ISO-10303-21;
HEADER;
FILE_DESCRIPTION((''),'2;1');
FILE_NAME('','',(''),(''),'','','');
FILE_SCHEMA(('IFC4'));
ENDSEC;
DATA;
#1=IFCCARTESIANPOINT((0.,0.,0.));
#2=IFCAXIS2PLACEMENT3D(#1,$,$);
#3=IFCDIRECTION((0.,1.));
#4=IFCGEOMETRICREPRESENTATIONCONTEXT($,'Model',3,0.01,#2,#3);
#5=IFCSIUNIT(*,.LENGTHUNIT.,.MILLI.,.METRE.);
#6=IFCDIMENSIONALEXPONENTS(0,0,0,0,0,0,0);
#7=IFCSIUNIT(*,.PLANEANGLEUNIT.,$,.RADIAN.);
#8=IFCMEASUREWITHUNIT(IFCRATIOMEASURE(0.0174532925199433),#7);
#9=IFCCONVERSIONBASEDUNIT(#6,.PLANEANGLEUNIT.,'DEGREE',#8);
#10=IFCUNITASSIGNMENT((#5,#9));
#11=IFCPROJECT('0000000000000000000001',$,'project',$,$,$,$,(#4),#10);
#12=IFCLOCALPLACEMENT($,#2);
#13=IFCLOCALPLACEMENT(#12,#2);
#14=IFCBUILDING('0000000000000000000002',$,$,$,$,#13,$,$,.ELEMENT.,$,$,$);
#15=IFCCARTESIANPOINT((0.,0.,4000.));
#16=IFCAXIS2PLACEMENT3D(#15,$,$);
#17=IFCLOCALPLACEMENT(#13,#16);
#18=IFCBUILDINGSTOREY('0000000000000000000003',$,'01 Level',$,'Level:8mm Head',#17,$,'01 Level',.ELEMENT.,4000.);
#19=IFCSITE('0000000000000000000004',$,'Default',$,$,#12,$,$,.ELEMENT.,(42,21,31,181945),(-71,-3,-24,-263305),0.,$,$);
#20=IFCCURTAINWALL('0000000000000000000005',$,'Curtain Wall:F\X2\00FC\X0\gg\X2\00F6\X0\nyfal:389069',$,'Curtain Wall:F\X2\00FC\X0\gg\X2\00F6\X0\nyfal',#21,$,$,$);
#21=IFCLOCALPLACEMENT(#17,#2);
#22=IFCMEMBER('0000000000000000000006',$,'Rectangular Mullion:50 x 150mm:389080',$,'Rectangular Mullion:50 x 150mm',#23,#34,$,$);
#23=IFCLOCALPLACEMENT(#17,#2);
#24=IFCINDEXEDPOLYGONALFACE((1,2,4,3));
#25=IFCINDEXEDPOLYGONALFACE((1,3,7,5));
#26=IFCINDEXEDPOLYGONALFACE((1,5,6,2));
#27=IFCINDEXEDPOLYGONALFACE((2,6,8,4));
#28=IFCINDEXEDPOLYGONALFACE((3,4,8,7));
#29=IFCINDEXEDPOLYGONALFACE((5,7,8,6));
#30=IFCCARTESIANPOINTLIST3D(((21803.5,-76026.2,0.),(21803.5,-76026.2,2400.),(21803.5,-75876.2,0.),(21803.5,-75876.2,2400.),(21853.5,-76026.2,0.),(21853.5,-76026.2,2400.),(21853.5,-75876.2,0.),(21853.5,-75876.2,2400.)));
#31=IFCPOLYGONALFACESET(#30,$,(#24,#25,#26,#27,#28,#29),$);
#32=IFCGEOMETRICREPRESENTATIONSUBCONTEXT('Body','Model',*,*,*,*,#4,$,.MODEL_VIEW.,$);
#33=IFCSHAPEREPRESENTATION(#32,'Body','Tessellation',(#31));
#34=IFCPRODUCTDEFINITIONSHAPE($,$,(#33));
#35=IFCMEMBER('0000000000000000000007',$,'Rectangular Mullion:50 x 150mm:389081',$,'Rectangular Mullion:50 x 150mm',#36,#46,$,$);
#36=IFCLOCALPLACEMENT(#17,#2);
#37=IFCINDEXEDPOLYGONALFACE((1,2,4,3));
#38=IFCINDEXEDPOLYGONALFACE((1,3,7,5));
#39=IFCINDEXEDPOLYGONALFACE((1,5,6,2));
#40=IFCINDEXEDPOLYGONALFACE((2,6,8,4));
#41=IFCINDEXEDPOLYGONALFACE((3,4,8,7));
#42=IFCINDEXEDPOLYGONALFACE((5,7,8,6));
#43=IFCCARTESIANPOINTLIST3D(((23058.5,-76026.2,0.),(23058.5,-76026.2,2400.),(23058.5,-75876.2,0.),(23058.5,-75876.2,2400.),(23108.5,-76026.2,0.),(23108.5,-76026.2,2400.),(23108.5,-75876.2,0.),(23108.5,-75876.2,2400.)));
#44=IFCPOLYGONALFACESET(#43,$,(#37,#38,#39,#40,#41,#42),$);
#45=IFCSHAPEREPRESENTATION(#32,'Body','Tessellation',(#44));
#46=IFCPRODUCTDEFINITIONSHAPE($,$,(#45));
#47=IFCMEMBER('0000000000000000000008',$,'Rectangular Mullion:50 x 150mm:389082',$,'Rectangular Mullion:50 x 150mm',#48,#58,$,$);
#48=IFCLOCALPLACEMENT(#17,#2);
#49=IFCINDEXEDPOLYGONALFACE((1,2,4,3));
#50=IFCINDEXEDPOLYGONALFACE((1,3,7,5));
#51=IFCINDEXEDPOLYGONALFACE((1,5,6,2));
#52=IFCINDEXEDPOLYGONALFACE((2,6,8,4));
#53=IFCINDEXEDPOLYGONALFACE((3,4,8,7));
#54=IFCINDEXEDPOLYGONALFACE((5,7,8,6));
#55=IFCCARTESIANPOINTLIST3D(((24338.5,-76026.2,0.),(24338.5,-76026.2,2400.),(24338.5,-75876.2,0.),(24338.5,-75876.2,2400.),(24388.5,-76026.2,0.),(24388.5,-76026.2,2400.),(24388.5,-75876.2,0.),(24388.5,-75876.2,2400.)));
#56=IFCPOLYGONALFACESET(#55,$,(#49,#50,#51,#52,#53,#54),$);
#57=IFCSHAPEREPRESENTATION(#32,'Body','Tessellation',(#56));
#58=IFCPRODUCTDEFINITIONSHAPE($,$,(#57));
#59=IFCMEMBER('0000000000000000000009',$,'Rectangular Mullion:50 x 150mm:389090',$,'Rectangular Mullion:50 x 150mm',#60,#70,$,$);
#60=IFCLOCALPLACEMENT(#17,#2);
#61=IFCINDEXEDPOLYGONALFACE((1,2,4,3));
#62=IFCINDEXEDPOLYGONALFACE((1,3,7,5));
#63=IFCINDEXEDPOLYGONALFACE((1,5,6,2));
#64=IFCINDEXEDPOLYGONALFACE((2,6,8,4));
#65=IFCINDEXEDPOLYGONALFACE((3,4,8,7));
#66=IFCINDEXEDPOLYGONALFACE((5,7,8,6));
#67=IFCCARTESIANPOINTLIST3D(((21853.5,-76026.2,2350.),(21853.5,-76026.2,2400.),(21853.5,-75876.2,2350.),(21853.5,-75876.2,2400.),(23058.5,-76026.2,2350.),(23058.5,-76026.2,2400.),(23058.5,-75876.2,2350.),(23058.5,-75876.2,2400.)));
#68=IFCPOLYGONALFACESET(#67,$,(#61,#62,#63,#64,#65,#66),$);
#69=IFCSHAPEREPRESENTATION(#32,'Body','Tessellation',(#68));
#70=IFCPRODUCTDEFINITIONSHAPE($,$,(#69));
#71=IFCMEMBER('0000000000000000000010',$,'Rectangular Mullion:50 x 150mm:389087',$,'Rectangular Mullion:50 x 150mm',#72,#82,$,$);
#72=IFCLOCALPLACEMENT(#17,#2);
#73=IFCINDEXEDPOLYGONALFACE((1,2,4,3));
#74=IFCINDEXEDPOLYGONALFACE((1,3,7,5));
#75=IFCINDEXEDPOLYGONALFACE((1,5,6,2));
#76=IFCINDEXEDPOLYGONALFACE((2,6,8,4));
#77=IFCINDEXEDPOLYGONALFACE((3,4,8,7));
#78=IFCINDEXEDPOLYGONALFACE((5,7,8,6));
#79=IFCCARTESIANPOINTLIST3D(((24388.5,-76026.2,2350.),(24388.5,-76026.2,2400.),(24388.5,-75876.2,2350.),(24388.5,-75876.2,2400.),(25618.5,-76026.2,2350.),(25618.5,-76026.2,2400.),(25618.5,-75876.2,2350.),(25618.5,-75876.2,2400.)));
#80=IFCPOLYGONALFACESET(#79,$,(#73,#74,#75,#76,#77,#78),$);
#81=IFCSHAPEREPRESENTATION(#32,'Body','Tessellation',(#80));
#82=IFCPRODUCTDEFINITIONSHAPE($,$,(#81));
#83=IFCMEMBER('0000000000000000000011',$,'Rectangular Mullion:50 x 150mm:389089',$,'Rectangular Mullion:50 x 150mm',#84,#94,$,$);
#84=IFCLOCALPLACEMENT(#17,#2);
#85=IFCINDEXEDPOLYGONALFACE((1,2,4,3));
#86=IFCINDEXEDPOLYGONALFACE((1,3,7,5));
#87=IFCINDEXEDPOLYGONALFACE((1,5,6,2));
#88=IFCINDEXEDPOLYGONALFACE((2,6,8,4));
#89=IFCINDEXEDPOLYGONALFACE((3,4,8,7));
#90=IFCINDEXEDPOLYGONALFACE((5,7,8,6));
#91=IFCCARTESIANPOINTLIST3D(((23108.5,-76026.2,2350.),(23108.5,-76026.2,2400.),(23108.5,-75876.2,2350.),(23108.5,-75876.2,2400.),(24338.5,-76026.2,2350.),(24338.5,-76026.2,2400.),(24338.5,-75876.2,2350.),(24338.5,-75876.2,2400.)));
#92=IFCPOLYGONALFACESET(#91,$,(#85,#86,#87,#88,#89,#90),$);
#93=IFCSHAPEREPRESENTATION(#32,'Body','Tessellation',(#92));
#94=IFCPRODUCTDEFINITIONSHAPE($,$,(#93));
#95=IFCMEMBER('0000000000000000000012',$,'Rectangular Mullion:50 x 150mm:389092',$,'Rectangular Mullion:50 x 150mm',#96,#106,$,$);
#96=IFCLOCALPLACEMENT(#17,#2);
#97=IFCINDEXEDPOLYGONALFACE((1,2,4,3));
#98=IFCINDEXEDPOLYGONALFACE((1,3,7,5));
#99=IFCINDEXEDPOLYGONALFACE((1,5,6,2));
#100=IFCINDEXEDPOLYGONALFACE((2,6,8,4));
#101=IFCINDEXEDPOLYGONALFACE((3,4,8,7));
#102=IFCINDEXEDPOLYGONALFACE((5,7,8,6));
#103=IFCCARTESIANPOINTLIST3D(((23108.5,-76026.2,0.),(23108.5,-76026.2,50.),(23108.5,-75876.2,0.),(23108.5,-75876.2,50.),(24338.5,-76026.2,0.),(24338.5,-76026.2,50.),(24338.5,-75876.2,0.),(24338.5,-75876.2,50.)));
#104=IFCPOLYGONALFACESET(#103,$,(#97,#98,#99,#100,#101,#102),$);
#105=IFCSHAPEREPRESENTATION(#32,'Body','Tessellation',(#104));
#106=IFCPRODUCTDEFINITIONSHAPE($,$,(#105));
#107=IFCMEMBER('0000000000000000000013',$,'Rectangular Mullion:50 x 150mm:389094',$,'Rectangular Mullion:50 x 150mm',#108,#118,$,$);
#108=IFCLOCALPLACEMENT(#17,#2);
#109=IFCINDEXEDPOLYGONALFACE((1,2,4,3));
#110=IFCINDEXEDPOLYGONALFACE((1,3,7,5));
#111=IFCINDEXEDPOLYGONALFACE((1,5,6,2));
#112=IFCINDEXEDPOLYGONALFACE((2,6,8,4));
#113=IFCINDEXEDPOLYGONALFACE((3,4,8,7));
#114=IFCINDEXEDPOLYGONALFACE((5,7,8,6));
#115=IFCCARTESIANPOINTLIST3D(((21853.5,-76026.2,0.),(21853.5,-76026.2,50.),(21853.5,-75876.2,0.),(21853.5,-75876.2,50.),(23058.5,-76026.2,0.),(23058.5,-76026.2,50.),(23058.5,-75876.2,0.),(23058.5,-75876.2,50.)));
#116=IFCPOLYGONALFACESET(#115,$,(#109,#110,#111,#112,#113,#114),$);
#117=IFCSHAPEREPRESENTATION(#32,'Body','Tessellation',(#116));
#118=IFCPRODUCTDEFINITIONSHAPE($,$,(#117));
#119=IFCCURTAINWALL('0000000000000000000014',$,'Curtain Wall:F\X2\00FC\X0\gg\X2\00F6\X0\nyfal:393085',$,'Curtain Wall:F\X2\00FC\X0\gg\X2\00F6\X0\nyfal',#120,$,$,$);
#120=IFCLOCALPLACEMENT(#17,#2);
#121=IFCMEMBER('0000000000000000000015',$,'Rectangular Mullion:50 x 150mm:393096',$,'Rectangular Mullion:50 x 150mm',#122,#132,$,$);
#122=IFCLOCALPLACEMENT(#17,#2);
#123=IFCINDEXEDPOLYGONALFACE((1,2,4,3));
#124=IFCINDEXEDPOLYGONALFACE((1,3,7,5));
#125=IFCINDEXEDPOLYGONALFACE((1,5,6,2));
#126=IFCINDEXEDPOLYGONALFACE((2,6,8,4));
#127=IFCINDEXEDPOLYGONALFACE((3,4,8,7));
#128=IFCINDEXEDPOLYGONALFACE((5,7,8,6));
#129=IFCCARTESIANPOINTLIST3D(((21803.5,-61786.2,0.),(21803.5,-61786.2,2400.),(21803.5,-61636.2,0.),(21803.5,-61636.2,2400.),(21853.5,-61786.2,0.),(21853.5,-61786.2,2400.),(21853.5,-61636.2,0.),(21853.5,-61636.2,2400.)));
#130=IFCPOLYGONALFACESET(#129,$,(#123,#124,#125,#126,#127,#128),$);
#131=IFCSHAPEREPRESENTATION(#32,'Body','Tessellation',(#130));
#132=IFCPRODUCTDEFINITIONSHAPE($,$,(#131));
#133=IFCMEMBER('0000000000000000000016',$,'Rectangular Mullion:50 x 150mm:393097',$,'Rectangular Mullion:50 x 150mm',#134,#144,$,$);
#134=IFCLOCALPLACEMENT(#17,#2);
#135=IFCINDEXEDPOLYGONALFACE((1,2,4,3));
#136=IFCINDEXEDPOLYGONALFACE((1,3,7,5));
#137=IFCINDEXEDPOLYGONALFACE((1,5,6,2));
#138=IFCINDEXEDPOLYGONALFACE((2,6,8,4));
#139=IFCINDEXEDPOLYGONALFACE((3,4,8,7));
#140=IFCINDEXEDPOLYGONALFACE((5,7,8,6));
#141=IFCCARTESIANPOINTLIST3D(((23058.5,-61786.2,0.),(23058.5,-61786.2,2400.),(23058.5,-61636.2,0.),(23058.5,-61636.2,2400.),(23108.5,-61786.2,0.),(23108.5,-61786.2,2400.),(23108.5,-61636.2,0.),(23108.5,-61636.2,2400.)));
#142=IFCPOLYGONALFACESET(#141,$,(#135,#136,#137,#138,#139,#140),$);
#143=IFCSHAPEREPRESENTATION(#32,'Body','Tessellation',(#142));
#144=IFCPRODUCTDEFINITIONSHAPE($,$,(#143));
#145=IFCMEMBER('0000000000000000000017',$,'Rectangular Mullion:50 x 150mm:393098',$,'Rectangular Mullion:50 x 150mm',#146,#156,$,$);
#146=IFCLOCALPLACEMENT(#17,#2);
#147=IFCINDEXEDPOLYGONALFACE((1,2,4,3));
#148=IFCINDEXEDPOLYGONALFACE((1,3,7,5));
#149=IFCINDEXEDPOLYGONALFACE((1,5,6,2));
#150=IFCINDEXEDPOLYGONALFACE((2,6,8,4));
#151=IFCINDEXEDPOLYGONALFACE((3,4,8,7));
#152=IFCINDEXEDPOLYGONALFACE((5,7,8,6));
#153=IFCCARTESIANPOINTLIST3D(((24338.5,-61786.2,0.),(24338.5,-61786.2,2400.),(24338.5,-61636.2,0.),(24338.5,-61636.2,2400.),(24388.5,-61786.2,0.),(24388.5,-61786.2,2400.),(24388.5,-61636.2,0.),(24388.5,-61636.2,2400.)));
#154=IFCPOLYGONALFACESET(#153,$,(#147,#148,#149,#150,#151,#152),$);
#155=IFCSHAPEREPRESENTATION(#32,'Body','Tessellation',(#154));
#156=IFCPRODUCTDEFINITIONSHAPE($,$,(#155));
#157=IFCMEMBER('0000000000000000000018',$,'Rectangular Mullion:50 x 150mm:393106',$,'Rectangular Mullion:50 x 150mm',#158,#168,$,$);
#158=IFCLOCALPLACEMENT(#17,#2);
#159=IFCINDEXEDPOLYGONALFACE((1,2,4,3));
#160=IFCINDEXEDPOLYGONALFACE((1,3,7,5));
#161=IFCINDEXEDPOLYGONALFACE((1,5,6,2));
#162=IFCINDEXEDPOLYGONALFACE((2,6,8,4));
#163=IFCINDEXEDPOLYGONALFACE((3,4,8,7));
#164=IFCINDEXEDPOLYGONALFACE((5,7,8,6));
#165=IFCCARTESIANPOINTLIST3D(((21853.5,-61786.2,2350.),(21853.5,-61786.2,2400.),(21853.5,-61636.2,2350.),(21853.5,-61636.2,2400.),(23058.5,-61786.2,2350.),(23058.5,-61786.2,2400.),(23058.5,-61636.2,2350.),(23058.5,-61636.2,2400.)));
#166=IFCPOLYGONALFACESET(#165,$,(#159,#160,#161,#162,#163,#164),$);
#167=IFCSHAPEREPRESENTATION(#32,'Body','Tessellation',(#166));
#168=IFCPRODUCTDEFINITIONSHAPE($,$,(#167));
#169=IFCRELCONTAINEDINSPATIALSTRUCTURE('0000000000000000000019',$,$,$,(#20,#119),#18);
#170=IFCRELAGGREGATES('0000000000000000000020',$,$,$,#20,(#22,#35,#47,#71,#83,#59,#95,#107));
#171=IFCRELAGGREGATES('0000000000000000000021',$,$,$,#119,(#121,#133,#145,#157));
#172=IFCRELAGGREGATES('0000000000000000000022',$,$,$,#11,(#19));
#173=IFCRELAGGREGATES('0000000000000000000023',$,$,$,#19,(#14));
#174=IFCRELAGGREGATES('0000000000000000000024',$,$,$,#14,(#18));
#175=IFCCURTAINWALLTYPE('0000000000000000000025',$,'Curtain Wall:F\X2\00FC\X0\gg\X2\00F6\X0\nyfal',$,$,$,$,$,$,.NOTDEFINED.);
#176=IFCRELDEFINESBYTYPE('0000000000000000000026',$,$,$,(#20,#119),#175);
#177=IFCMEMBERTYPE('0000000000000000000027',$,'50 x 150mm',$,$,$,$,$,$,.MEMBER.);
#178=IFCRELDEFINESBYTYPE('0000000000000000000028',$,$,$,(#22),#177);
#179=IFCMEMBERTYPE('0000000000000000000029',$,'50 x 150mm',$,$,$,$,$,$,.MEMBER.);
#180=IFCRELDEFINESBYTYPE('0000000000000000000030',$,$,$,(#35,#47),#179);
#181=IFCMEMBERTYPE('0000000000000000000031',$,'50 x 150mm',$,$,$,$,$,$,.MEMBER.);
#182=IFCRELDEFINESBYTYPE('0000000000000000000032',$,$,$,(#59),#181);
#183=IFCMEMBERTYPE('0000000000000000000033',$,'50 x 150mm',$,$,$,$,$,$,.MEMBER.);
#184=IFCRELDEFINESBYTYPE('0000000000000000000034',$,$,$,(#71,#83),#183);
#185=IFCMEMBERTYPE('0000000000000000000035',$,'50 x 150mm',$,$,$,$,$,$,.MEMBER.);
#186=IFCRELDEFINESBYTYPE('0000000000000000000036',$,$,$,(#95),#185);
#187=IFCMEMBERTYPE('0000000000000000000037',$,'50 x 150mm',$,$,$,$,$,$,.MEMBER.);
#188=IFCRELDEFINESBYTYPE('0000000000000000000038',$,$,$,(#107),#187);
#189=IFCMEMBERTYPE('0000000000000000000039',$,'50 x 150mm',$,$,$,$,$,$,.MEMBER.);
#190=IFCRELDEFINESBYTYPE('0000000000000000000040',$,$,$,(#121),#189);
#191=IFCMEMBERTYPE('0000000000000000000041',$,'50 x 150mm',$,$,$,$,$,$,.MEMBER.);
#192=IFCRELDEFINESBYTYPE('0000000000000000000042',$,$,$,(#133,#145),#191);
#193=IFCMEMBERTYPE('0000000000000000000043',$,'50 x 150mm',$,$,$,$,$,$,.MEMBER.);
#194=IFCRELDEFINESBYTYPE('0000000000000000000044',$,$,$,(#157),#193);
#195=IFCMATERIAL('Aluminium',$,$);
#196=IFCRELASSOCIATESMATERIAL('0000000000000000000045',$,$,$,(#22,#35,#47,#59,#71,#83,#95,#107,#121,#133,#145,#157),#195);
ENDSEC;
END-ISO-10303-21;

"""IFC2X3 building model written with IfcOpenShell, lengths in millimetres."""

from ifc_helpers import new_model, entity, si_unit, converted_unit, direction, frame, origin, origin_2d_with_axis, place, context, subcontext, project, spatial, rectangle, extrude, source, transform, mapped, material, type_object, type_shapes, element, aggregate, save


model = new_model("IFC2X3")

# Units and contexts
model_context = context("Model", 3, precision=0.01, world=origin(), true_north=direction((0.0, 1.0)))
body_context = subcontext(model_context, "Body", "Model", "MODEL_VIEW")
ifc_project = project(units=[si_unit("LENGTHUNIT", "METRE", prefix="MILLI"), converted_unit("PLANEANGLEUNIT", "DEGREE", entity("IfcRatioMeasure", 0.0174532925199433), si_unit("PLANEANGLEUNIT", "RADIAN"), dimensions=[0, 0, 0, 0, 0, 0, 0])], contexts=[model_context])

# Site, building, storey
site_placement = place(None, origin())
site = spatial("IfcSite", under=ifc_project, at=site_placement, Name="Default", CompositionType="ELEMENT", RefLatitude=(42, 21, 31, 181945), RefLongitude=(-71, -3, -24, -263305), RefElevation=0.0)
building_placement = place(site_placement, origin())
building = spatial("IfcBuilding", under=site, at=building_placement, CompositionType="ELEMENT")
storey_placement = place(building_placement, frame((0.0, 0.0, 4000.0)))
storey = spatial("IfcBuildingStorey", under=building, at=storey_placement, Name="01 Level", ObjectType="Level:8mm Head", LongName="01 Level", CompositionType="ELEMENT", Elevation=4000.0)

# Curtain walls, members
curtain_wall_type = type_object("IfcCurtainWallType", Name="Curtain Wall:Függönyfal", PredefinedType="NOTDEFINED")
curtain_wall_1_placement = place(storey_placement, frame((0.0, 0.0, -4000.0)))
curtain_wall_1 = element("IfcCurtainWall", 1, at=curtain_wall_1_placement, inside=storey, type_object=curtain_wall_type, Name="Curtain Wall:Függönyfal:389069", ObjectType="Curtain Wall:Függönyfal")
ifc_material_1 = material(Name="Aluminium")
member_type_1 = type_object("IfcMemberType", Name="50 x 150mm", PredefinedType="MEMBER")
shared_shape_1 = source(origin(), body_context, "Body", "SweptSolid", [
    extrude(rectangle(XDim=150.0, YDim=50.0, at=origin_2d_with_axis()), frame((-25.0, 0.0, -2400.0), z_axis=(0.0, 0.0, 1.0), x_axis=(0.0, -1.0, 0.0)), (0.0, 0.0, 1.0), 2400.0),
])
type_shapes(member_type_1, [shared_shape_1])
member_1_placement = place(storey_placement, frame((21803.5, -75951.2, 0.0), z_axis=(0.0, 0.0, -1.0), x_axis=(-1.0, 0.0, 0.0)))
member_1 = element("IfcMember", 2, at=member_1_placement, type_object=member_type_1, material=ifc_material_1, Name="Rectangular Mullion:50 x 150mm:389080", ObjectType="Rectangular Mullion:50 x 150mm", context=body_context, shape_type="MappedRepresentation", body=[
    mapped(shared_shape_1, transform((0.0, 0.0, 0.0), scale=1.0)),
])
member_type_2 = type_object("IfcMemberType", Name="50 x 150mm", PredefinedType="MEMBER")
shared_shape_2 = source(origin(), body_context, "Body", "SweptSolid", [
    extrude(rectangle(XDim=150.0, YDim=50.0, at=origin_2d_with_axis()), frame((0.0, 0.0, -2400.0), z_axis=(0.0, 0.0, 1.0), x_axis=(0.0, -1.0, 0.0)), (0.0, 0.0, 1.0), 2400.0),
])
type_shapes(member_type_2, [shared_shape_2])
member_2_placement = place(storey_placement, frame((23083.5, -75951.2, 0.0), z_axis=(0.0, 0.0, -1.0), x_axis=(-1.0, 0.0, 0.0)))
member_2 = element("IfcMember", 3, at=member_2_placement, type_object=member_type_2, material=ifc_material_1, Name="Rectangular Mullion:50 x 150mm:389081", ObjectType="Rectangular Mullion:50 x 150mm", context=body_context, shape_type="MappedRepresentation", body=[
    mapped(shared_shape_2, transform((0.0, 0.0, 0.0), scale=1.0)),
])
member_3_placement = place(storey_placement, frame((24363.5, -75951.2, 0.0), z_axis=(0.0, 0.0, -1.0), x_axis=(-1.0, 0.0, 0.0)))
member_3 = element("IfcMember", 4, at=member_3_placement, type_object=member_type_2, material=ifc_material_1, Name="Rectangular Mullion:50 x 150mm:389082", ObjectType="Rectangular Mullion:50 x 150mm", context=body_context, shape_type="MappedRepresentation", body=[
    mapped(shared_shape_2, transform((0.0, 0.0, 0.0), scale=1.0)),
])
member_type_3 = type_object("IfcMemberType", Name="50 x 150mm", PredefinedType="MEMBER")
shared_shape_3 = source(origin(), body_context, "Body", "SweptSolid", [
    extrude(rectangle(XDim=150.0, YDim=50.0, at=origin_2d_with_axis()), frame((-25.0, 0.0, -1205.0), z_axis=(0.0, 0.0, 1.0), x_axis=(0.0, -1.0, 0.0)), (0.0, 0.0, 1.0), 1205.0),
])
type_shapes(member_type_3, [shared_shape_3])
member_4_placement = place(storey_placement, frame((21853.5, -75951.2, 2400.0), z_axis=(-1.0, 0.0, 0.0), x_axis=(0.0, 0.0, 1.0)))
member_4 = element("IfcMember", 5, at=member_4_placement, type_object=member_type_3, material=ifc_material_1, Name="Rectangular Mullion:50 x 150mm:389090", ObjectType="Rectangular Mullion:50 x 150mm", context=body_context, shape_type="MappedRepresentation", body=[
    mapped(shared_shape_3, transform((0.0, 0.0, 0.0), scale=1.0)),
])
member_type_4 = type_object("IfcMemberType", Name="50 x 150mm", PredefinedType="MEMBER")
shared_shape_4 = source(origin(), body_context, "Body", "SweptSolid", [
    extrude(rectangle(XDim=150.0, YDim=50.0, at=origin_2d_with_axis()), frame((-25.0, 0.0, -1230.0), z_axis=(0.0, 0.0, 1.0), x_axis=(0.0, -1.0, 0.0)), (0.0, 0.0, 1.0), 1230.0),
])
type_shapes(member_type_4, [shared_shape_4])
member_5_placement = place(storey_placement, frame((24388.5, -75951.2, 2400.0), z_axis=(-1.0, 0.0, 0.0), x_axis=(0.0, 0.0, 1.0)))
member_5 = element("IfcMember", 6, at=member_5_placement, type_object=member_type_4, material=ifc_material_1, Name="Rectangular Mullion:50 x 150mm:389087", ObjectType="Rectangular Mullion:50 x 150mm", context=body_context, shape_type="MappedRepresentation", body=[
    mapped(shared_shape_4, transform((0.0, 0.0, 0.0), scale=1.0)),
])
member_6_placement = place(storey_placement, frame((23108.5, -75951.2, 2400.0), z_axis=(-1.0, 0.0, 0.0), x_axis=(0.0, 0.0, 1.0)))
member_6 = element("IfcMember", 7, at=member_6_placement, type_object=member_type_4, material=ifc_material_1, Name="Rectangular Mullion:50 x 150mm:389089", ObjectType="Rectangular Mullion:50 x 150mm", context=body_context, shape_type="MappedRepresentation", body=[
    mapped(shared_shape_4, transform((0.0, 0.0, 0.0), scale=1.0)),
])
member_type_5 = type_object("IfcMemberType", Name="50 x 150mm", PredefinedType="MEMBER")
shared_shape_5 = source(origin(), body_context, "Body", "SweptSolid", [
    extrude(rectangle(XDim=150.0, YDim=50.0, at=origin_2d_with_axis()), frame((-25.0, 0.0, -1230.0), z_axis=(0.0, 0.0, 1.0), x_axis=(0.0, -1.0, 0.0)), (0.0, 0.0, 1.0), 1230.0),
])
type_shapes(member_type_5, [shared_shape_5])
member_7_placement = place(storey_placement, frame((24338.5, -75951.2, 0.0), z_axis=(1.0, 0.0, 0.0), x_axis=(0.0, 0.0, -1.0)))
member_7 = element("IfcMember", 8, at=member_7_placement, type_object=member_type_5, material=ifc_material_1, Name="Rectangular Mullion:50 x 150mm:389092", ObjectType="Rectangular Mullion:50 x 150mm", context=body_context, shape_type="MappedRepresentation", body=[
    mapped(shared_shape_5, transform((0.0, 0.0, 0.0), scale=1.0)),
])
member_type_6 = type_object("IfcMemberType", Name="50 x 150mm", PredefinedType="MEMBER")
shared_shape_6 = source(origin(), body_context, "Body", "SweptSolid", [
    extrude(rectangle(XDim=150.0, YDim=50.0, at=origin_2d_with_axis()), frame((-25.0, 0.0, -1205.0), z_axis=(0.0, 0.0, 1.0), x_axis=(0.0, -1.0, 0.0)), (0.0, 0.0, 1.0), 1205.0),
])
type_shapes(member_type_6, [shared_shape_6])
member_8_placement = place(storey_placement, frame((23058.5, -75951.2, 0.0), z_axis=(1.0, 0.0, 0.0), x_axis=(0.0, 0.0, -1.0)))
member_8 = element("IfcMember", 9, at=member_8_placement, type_object=member_type_6, material=ifc_material_1, Name="Rectangular Mullion:50 x 150mm:389094", ObjectType="Rectangular Mullion:50 x 150mm", context=body_context, shape_type="MappedRepresentation", body=[
    mapped(shared_shape_6, transform((0.0, 0.0, 0.0), scale=1.0)),
])
curtain_wall_2_placement = place(storey_placement, frame((0.0, 0.0, -4000.0)))
curtain_wall_2 = element("IfcCurtainWall", 10, at=curtain_wall_2_placement, inside=storey, type_object=curtain_wall_type, Name="Curtain Wall:Függönyfal:393085", ObjectType="Curtain Wall:Függönyfal")
member_type_7 = type_object("IfcMemberType", Name="50 x 150mm", PredefinedType="MEMBER")
shared_shape_7 = source(origin(), body_context, "Body", "SweptSolid", [
    extrude(rectangle(XDim=150.0, YDim=50.0, at=origin_2d_with_axis()), frame((-25.0, 0.0, -2400.0), z_axis=(0.0, 0.0, 1.0), x_axis=(0.0, -1.0, 0.0)), (0.0, 0.0, 1.0), 2400.0),
])
type_shapes(member_type_7, [shared_shape_7])
member_9_placement = place(storey_placement, frame((21803.5, -61711.2, 0.0), z_axis=(0.0, 0.0, -1.0), x_axis=(-1.0, 0.0, 0.0)))
member_9 = element("IfcMember", 11, at=member_9_placement, type_object=member_type_7, material=ifc_material_1, Name="Rectangular Mullion:50 x 150mm:393096", ObjectType="Rectangular Mullion:50 x 150mm", context=body_context, shape_type="MappedRepresentation", body=[
    mapped(shared_shape_7, transform((0.0, 0.0, 0.0), scale=1.0)),
])
member_type_8 = type_object("IfcMemberType", Name="50 x 150mm", PredefinedType="MEMBER")
shared_shape_8 = source(origin(), body_context, "Body", "SweptSolid", [
    extrude(rectangle(XDim=150.0, YDim=50.0, at=origin_2d_with_axis()), frame((0.0, 0.0, -2400.0), z_axis=(0.0, 0.0, 1.0), x_axis=(0.0, -1.0, 0.0)), (0.0, 0.0, 1.0), 2400.0),
])
type_shapes(member_type_8, [shared_shape_8])
member_10_placement = place(storey_placement, frame((23083.5, -61711.2, 0.0), z_axis=(0.0, 0.0, -1.0), x_axis=(-1.0, 0.0, 0.0)))
member_10 = element("IfcMember", 12, at=member_10_placement, type_object=member_type_8, material=ifc_material_1, Name="Rectangular Mullion:50 x 150mm:393097", ObjectType="Rectangular Mullion:50 x 150mm", context=body_context, shape_type="MappedRepresentation", body=[
    mapped(shared_shape_8, transform((0.0, 0.0, 0.0), scale=1.0)),
])
member_11_placement = place(storey_placement, frame((24363.5, -61711.2, 0.0), z_axis=(0.0, 0.0, -1.0), x_axis=(-1.0, 0.0, 0.0)))
member_11 = element("IfcMember", 13, at=member_11_placement, type_object=member_type_8, material=ifc_material_1, Name="Rectangular Mullion:50 x 150mm:393098", ObjectType="Rectangular Mullion:50 x 150mm", context=body_context, shape_type="MappedRepresentation", body=[
    mapped(shared_shape_8, transform((0.0, 0.0, 0.0), scale=1.0)),
])
member_type_9 = type_object("IfcMemberType", Name="50 x 150mm", PredefinedType="MEMBER")
shared_shape_9 = source(origin(), body_context, "Body", "SweptSolid", [
    extrude(rectangle(XDim=150.0, YDim=50.0, at=origin_2d_with_axis()), frame((-25.0, 0.0, -1205.0), z_axis=(0.0, 0.0, 1.0), x_axis=(0.0, -1.0, 0.0)), (0.0, 0.0, 1.0), 1205.0),
])
type_shapes(member_type_9, [shared_shape_9])
member_12_placement = place(storey_placement, frame((21853.5, -61711.2, 2400.0), z_axis=(-1.0, 0.0, 0.0), x_axis=(0.0, 0.0, 1.0)))
member_12 = element("IfcMember", 14, at=member_12_placement, type_object=member_type_9, material=ifc_material_1, Name="Rectangular Mullion:50 x 150mm:393106", ObjectType="Rectangular Mullion:50 x 150mm", context=body_context, shape_type="MappedRepresentation", body=[
    mapped(shared_shape_9, transform((0.0, 0.0, 0.0), scale=1.0)),
])

aggregate(curtain_wall_1, [member_1, member_2, member_3, member_5, member_6, member_4, member_7, member_8])
aggregate(curtain_wall_2, [member_9, member_10, member_11, member_12])

save(model, "model.ifc")
